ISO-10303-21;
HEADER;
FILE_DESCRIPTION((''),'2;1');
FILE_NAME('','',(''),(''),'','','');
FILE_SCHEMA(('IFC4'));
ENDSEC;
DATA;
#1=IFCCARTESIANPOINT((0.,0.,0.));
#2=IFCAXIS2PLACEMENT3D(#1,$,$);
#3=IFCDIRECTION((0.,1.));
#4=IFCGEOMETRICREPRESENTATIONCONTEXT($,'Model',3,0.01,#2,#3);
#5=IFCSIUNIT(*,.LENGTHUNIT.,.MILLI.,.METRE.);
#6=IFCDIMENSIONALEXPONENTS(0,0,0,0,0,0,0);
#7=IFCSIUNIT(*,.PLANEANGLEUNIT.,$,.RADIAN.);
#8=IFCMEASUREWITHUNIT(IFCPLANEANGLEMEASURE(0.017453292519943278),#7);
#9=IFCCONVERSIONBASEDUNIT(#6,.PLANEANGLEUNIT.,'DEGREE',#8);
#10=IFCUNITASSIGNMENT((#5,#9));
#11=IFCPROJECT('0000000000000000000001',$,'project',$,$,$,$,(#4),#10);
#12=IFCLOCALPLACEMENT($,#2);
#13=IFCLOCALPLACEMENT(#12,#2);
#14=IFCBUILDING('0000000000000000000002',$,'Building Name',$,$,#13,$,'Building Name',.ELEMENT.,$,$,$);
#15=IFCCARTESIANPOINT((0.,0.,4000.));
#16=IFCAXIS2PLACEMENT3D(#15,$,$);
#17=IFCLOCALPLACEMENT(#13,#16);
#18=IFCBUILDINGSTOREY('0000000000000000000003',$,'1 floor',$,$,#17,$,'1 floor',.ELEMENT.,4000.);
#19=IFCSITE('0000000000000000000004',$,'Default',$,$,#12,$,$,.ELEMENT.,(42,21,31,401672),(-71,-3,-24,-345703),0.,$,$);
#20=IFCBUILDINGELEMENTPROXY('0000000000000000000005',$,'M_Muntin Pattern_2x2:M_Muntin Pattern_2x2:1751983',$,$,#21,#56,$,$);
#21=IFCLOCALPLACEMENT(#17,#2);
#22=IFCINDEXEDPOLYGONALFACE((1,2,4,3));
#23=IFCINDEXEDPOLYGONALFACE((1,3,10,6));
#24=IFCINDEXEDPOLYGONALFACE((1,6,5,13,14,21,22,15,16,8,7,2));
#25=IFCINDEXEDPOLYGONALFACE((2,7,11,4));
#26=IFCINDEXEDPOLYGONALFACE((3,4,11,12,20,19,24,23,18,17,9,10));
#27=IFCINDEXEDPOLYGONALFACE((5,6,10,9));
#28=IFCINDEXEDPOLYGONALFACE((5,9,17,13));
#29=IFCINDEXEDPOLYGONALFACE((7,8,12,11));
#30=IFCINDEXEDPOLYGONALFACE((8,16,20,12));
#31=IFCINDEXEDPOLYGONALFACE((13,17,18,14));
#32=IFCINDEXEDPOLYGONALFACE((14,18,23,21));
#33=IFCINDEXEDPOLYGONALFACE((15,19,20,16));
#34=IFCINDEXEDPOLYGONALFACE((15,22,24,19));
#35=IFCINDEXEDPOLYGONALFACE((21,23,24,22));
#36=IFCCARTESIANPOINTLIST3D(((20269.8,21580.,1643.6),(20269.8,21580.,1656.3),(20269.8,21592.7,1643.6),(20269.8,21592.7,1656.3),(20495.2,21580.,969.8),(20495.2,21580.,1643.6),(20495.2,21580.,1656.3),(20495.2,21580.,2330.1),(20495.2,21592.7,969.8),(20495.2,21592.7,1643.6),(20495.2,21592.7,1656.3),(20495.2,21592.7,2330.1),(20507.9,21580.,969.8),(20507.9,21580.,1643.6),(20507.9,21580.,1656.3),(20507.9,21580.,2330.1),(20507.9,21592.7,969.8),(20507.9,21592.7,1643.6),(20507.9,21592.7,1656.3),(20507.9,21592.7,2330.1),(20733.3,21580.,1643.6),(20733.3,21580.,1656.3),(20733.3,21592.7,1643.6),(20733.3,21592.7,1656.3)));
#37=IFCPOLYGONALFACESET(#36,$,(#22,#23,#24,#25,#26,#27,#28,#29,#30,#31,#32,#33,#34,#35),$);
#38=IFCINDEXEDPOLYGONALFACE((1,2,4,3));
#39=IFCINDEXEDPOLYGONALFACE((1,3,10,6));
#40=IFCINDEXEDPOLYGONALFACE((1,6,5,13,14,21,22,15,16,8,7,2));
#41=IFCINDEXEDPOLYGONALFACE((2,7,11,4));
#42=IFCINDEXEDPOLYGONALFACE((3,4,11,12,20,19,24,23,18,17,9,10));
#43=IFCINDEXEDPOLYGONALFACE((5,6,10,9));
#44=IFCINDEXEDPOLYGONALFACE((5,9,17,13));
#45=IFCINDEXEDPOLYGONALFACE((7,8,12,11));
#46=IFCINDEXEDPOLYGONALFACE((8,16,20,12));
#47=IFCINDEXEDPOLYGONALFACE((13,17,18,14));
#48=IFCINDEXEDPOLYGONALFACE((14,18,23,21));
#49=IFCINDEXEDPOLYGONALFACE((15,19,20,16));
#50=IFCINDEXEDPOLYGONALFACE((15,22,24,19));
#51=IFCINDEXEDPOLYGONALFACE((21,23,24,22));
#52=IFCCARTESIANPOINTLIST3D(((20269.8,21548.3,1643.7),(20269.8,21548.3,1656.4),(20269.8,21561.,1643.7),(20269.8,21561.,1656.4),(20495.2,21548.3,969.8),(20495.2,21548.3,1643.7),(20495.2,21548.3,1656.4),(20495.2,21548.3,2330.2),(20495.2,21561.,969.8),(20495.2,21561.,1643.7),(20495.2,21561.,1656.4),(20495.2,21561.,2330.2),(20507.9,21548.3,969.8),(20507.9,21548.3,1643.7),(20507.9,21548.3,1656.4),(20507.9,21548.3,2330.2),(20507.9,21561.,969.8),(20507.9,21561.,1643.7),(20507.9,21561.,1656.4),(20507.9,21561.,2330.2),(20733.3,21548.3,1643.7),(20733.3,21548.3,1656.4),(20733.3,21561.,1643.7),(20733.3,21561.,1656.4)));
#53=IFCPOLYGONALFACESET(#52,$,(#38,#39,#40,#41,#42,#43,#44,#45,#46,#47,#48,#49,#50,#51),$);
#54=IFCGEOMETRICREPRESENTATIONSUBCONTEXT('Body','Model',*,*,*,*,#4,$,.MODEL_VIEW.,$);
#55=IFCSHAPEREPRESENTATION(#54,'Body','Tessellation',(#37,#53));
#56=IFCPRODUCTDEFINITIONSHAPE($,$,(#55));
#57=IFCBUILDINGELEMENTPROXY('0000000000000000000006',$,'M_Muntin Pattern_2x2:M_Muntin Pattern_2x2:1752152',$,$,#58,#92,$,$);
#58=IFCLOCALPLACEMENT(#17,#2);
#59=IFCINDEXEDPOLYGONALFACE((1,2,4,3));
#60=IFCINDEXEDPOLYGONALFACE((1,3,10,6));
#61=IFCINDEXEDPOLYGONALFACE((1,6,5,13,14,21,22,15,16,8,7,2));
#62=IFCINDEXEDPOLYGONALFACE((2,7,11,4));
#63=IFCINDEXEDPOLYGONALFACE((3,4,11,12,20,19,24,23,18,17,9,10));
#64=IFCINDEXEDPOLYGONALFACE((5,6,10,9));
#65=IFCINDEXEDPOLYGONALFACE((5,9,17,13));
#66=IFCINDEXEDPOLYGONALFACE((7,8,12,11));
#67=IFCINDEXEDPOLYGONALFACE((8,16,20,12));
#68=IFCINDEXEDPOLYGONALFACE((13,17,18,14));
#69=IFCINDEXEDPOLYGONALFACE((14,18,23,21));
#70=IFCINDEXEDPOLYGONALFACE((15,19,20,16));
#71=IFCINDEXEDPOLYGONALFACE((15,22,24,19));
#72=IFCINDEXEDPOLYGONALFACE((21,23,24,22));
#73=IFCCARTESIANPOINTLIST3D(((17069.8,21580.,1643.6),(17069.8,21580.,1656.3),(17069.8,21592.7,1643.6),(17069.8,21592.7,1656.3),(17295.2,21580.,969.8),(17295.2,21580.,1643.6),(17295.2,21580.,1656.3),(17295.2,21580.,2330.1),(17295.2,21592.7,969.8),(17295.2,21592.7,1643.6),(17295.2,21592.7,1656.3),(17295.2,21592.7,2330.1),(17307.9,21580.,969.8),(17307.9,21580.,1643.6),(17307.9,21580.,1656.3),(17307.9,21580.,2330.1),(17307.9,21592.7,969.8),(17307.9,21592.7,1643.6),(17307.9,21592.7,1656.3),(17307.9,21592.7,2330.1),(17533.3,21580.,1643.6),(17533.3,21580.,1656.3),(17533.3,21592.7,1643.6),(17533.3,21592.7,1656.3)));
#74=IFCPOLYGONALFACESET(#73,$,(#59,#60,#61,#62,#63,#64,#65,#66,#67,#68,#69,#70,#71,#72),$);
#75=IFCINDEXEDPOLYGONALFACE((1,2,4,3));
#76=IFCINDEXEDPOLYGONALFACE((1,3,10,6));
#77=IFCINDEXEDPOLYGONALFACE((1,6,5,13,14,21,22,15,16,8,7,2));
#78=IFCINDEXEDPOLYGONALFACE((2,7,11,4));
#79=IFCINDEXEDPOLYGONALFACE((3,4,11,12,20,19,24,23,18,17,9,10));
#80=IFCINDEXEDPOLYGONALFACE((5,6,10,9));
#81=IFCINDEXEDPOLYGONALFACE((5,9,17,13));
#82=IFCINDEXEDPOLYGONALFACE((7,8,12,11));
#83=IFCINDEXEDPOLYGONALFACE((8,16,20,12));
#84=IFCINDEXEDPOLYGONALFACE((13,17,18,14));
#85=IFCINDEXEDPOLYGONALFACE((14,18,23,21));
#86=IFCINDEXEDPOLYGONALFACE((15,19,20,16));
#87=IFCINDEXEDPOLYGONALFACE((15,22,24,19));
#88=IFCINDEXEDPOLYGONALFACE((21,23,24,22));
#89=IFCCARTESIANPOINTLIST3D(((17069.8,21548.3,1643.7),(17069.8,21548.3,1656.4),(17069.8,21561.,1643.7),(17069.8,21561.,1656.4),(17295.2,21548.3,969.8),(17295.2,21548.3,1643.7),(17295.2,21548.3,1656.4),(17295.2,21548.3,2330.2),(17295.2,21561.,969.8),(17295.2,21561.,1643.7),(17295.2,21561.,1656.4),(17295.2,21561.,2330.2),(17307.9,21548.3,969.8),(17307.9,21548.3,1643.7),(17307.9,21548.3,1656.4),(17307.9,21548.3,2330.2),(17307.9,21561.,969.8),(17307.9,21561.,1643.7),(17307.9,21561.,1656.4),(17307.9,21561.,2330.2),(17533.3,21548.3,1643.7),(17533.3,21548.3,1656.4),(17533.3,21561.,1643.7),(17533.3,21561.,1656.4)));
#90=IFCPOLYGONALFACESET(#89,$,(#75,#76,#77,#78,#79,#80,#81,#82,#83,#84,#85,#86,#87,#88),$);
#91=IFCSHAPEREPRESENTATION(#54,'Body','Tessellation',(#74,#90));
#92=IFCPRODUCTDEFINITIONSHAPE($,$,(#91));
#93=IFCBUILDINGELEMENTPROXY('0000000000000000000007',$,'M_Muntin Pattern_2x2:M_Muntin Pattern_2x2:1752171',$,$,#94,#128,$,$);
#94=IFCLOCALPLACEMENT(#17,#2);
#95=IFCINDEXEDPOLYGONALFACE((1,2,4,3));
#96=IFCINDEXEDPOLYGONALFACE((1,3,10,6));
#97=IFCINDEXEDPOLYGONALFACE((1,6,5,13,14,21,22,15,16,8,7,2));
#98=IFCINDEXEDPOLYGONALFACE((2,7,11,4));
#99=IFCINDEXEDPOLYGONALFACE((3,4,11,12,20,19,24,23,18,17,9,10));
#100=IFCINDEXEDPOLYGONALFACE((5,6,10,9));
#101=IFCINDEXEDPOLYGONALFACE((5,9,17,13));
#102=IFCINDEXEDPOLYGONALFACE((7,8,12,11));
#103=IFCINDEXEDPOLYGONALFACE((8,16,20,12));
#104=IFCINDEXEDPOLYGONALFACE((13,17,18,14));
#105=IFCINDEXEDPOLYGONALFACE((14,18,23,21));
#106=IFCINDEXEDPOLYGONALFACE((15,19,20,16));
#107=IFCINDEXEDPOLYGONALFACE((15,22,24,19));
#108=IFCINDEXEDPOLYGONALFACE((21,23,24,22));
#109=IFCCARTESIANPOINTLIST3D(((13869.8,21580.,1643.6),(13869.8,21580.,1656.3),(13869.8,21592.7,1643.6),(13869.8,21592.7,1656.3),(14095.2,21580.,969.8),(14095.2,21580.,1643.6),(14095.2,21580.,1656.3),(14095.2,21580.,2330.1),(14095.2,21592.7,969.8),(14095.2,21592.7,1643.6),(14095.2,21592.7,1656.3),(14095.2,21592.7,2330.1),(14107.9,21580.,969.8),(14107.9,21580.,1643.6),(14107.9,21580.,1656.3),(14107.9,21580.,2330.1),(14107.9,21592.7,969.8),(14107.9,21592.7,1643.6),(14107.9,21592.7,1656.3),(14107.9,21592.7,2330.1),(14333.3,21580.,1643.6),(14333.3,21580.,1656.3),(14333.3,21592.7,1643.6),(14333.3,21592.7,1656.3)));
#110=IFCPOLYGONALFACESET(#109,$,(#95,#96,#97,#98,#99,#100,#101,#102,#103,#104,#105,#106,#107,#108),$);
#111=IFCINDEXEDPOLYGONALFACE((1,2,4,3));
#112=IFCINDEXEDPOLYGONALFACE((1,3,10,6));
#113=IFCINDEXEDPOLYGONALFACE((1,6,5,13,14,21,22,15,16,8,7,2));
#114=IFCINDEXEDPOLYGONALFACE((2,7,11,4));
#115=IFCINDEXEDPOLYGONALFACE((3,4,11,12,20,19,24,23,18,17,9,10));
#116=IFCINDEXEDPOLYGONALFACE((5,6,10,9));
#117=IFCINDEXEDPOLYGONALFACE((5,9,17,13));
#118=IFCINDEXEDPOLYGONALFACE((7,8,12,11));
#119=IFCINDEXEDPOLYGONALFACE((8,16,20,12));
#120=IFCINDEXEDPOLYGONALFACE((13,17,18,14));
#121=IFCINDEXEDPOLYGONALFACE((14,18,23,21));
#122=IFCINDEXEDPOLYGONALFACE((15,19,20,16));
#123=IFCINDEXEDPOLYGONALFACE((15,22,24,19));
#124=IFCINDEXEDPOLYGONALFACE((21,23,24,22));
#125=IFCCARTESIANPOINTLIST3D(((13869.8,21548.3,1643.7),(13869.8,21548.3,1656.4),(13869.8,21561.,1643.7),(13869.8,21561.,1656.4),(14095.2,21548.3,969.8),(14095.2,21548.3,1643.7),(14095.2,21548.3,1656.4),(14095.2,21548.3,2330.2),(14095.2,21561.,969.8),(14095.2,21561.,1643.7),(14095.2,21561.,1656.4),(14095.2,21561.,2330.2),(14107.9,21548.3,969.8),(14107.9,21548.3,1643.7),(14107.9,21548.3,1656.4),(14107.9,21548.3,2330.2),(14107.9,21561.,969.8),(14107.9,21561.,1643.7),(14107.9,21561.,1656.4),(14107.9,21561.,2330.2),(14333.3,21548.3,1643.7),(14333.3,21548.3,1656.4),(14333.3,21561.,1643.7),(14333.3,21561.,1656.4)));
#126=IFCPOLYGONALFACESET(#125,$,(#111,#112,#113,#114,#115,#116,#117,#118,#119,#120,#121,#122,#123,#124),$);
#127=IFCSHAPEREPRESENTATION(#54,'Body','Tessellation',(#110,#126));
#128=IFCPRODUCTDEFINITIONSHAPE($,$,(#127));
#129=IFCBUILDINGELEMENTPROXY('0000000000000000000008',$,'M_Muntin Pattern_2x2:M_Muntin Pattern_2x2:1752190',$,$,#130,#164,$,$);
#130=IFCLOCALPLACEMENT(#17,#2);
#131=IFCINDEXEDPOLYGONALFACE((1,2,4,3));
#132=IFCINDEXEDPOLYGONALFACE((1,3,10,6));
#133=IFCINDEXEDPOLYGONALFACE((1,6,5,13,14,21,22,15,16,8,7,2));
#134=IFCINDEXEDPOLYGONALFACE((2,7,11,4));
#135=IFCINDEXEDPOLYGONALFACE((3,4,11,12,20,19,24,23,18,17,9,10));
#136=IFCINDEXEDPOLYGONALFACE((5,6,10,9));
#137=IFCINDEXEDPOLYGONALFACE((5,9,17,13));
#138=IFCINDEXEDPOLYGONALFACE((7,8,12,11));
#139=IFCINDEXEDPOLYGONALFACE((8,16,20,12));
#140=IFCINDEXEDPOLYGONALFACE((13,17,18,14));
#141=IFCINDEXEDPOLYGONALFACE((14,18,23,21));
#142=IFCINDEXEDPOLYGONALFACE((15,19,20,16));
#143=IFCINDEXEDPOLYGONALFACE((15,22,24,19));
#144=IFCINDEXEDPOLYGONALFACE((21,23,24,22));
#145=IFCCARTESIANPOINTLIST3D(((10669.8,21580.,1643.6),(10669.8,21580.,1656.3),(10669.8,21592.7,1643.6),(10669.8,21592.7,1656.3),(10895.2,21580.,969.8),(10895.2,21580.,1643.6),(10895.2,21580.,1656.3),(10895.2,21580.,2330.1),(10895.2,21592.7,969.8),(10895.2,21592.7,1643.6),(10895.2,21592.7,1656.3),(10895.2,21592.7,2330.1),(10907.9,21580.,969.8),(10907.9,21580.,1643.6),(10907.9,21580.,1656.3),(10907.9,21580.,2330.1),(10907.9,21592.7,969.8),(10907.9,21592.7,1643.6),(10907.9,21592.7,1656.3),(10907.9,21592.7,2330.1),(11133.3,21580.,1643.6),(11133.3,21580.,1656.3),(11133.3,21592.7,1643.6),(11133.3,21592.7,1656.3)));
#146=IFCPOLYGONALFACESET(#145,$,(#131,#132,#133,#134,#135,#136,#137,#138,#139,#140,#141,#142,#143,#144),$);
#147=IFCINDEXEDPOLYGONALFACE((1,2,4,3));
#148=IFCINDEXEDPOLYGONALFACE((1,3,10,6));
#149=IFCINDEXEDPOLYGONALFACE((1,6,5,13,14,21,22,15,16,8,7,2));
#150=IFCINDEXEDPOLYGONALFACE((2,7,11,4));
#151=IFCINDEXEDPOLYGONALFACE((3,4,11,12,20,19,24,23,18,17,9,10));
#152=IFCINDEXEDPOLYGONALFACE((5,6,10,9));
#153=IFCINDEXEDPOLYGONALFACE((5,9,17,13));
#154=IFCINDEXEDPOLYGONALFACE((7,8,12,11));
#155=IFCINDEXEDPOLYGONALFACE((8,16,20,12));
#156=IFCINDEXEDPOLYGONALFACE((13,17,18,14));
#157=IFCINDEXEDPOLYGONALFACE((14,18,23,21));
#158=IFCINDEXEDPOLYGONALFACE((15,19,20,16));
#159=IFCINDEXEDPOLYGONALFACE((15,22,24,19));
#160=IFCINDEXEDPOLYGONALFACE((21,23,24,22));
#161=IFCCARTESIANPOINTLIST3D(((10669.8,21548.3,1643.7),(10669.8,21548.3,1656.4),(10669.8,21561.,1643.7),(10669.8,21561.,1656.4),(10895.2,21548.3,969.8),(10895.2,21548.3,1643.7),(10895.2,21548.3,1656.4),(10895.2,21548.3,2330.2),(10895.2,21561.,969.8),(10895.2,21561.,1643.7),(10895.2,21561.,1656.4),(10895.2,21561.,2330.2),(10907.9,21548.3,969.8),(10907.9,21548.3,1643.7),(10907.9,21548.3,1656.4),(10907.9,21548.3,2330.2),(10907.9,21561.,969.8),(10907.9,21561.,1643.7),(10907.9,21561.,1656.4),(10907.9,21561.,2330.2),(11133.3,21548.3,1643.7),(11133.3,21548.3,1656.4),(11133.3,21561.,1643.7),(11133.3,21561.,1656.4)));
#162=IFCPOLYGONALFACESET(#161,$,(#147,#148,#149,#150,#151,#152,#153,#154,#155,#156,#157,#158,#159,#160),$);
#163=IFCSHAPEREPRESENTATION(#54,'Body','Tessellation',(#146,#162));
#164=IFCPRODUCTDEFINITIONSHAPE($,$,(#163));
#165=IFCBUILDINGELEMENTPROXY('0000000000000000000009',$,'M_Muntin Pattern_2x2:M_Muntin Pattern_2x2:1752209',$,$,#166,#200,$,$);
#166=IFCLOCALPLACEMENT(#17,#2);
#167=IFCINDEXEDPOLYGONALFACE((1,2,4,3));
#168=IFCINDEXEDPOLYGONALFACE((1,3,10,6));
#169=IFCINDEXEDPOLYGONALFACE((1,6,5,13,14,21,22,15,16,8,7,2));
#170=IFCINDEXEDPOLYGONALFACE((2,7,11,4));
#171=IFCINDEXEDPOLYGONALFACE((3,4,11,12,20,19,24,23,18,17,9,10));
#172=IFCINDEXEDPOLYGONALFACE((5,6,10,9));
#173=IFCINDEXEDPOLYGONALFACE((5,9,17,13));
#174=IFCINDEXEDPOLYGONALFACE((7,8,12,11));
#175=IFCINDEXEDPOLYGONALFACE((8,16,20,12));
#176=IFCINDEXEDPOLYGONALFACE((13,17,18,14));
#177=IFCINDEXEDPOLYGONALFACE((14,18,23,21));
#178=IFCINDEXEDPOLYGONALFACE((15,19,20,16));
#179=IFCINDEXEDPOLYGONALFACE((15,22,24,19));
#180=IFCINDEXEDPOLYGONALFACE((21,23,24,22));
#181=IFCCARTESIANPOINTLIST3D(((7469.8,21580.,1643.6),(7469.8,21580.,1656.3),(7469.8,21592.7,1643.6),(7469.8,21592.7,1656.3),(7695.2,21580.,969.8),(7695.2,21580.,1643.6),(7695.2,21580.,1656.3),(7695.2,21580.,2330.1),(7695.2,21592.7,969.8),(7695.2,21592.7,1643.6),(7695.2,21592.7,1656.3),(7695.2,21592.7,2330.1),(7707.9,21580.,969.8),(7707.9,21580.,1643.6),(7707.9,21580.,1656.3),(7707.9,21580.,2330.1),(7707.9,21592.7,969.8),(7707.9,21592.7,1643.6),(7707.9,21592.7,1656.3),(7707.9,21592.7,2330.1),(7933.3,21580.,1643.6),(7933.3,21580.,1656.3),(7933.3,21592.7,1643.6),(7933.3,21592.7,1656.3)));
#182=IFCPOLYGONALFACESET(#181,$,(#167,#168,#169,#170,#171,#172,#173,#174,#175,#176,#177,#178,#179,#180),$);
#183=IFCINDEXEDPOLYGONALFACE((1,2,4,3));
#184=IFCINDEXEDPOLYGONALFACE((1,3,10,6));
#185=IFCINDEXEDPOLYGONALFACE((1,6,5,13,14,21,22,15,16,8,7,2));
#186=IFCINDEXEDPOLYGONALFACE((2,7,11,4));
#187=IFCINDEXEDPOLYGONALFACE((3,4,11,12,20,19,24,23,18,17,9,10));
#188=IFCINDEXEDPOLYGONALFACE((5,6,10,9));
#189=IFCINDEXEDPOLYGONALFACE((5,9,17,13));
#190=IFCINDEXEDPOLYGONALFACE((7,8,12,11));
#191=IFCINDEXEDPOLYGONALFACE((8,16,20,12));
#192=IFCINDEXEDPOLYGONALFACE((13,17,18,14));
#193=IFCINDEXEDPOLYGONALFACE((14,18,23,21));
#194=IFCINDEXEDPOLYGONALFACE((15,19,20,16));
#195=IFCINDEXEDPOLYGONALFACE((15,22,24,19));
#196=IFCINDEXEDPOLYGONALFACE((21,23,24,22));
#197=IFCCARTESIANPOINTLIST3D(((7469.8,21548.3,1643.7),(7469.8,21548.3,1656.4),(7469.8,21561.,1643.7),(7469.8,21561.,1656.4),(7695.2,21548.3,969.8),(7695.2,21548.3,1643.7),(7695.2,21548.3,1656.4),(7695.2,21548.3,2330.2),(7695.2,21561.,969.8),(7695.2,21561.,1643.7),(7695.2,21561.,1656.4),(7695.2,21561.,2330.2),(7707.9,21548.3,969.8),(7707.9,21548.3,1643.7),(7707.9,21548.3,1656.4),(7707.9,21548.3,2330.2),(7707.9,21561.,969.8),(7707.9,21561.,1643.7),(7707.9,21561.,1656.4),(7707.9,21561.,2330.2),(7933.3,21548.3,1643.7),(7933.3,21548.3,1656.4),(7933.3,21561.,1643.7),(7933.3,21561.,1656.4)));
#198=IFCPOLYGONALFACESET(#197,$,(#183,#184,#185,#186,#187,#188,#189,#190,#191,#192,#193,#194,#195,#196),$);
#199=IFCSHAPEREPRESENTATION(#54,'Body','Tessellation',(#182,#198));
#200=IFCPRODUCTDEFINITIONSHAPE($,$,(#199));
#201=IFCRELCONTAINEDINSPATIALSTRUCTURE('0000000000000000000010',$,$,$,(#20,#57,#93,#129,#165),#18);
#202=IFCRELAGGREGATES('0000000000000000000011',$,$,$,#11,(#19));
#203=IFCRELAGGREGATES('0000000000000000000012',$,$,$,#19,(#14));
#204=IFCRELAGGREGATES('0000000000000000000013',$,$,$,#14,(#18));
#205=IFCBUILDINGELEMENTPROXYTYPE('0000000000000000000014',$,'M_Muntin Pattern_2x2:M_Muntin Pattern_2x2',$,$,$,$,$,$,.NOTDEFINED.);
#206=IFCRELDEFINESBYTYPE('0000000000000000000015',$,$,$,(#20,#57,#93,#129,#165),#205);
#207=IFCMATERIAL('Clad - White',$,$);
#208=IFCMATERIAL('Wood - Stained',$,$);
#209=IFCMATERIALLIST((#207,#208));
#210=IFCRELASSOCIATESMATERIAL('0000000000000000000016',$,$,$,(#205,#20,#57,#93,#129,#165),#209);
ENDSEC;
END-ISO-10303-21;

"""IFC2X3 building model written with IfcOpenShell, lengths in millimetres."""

from ifc_helpers import new_model, entity, si_unit, converted_unit, direction, frame, origin, place, context, subcontext, project, spatial, polyline, outline, extrude, source, transform, mapped, material, material_list, type_object, type_shapes, element, save


model = new_model("IFC2X3")

# Units and contexts
model_context = context("Model", 3, precision=0.01, world=origin(), true_north=direction((0.0, 1.0)))
body_context = subcontext(model_context, "Body", "Model", "MODEL_VIEW")
ifc_project = project(units=[si_unit("LENGTHUNIT", "METRE", prefix="MILLI"), converted_unit("PLANEANGLEUNIT", "DEGREE", entity("IfcPlaneAngleMeasure", 0.017453292519943278), si_unit("PLANEANGLEUNIT", "RADIAN"), dimensions=[0, 0, 0, 0, 0, 0, 0])], contexts=[model_context])

# Site, building, storey
site_placement = place(None, origin())
site = spatial("IfcSite", under=ifc_project, at=site_placement, Name="Default", CompositionType="ELEMENT", RefLatitude=(42, 21, 31, 401672), RefLongitude=(-71, -3, -24, -345703), RefElevation=0.0)
building_placement = place(site_placement, origin())
building = spatial("IfcBuilding", under=site, at=building_placement, Name="Building Name", LongName="Building Name", CompositionType="ELEMENT")
storey_placement = place(building_placement, frame((0.0, 0.0, 4000.0)))
storey = spatial("IfcBuildingStorey", under=building, at=storey_placement, Name="1 floor", LongName="1 floor", CompositionType="ELEMENT", Elevation=4000.0)

# Building element proxies
ifc_material_1 = material(Name="Clad - White")
ifc_material_2 = material(Name="Wood - Stained")
ifc_material_list = material_list([ifc_material_1, ifc_material_2])
building_element_proxy_type_1 = type_object("IfcBuildingElementProxyType", Name="M_Muntin Pattern_2x2:M_Muntin Pattern_2x2", PredefinedType="NOTDEFINED", material=ifc_material_list)
shared_shape_1 = source(origin(), body_context, "Body", "SweptSolid", [
    extrude(outline(polyline([(6.4, -6.4), (680.1, -6.4), (680.1, 6.3), (6.4, 6.3), (6.4, 231.7), (-6.3, 231.7), (-6.3, 6.3), (-680.2, 6.3), (-680.2, -6.4), (-6.3, -6.4), (-6.3, -231.7), (6.4, -231.7), (6.4, -6.4)])), frame((0.0, 9.5, 680.1), z_axis=(0.0, 1.0, 0.0), x_axis=(0.0, 0.0, 1.0)), (0.0, 0.0, 1.0), 12.7),
    extrude(outline(polyline([(6.4, -6.4), (680.2, -6.4), (680.2, 6.3), (6.4, 6.3), (6.4, 231.7), (-6.3, 231.7), (-6.3, 6.3), (-680.2, 6.3), (-680.2, -6.4), (-6.3, -6.4), (-6.3, -231.7), (6.4, -231.7), (6.4, -6.4)])), frame((0.0, -22.2, 680.2), z_axis=(0.0, 1.0, 0.0), x_axis=(0.0, 0.0, 1.0)), (0.0, 0.0, 1.0), 12.7),
])
type_shapes(building_element_proxy_type_1, [shared_shape_1])
for number, where, name in (
    (1, (20501.6, 21570.5, 969.8), "M_Muntin Pattern_2x2:M_Muntin Pattern_2x2:1751983"),
    (2, (17301.6, 21570.5, 969.8), "M_Muntin Pattern_2x2:M_Muntin Pattern_2x2:1752152"),
    (3, (14101.6, 21570.5, 969.8), "M_Muntin Pattern_2x2:M_Muntin Pattern_2x2:1752171"),
    (4, (10901.6, 21570.5, 969.8), "M_Muntin Pattern_2x2:M_Muntin Pattern_2x2:1752190"),
    (5, (7701.6, 21570.5, 969.8), "M_Muntin Pattern_2x2:M_Muntin Pattern_2x2:1752209"),
):
    element("IfcBuildingElementProxy", number, at=place(storey_placement, frame(where)), inside=storey, type_object=building_element_proxy_type_1, material=ifc_material_list, Name=name, context=body_context, shape_type="MappedRepresentation", body=[
        mapped(shared_shape_1, transform((0.0, 0.0, 0.0), scale=1.0)),
    ])

save(model, "model.ifc")
